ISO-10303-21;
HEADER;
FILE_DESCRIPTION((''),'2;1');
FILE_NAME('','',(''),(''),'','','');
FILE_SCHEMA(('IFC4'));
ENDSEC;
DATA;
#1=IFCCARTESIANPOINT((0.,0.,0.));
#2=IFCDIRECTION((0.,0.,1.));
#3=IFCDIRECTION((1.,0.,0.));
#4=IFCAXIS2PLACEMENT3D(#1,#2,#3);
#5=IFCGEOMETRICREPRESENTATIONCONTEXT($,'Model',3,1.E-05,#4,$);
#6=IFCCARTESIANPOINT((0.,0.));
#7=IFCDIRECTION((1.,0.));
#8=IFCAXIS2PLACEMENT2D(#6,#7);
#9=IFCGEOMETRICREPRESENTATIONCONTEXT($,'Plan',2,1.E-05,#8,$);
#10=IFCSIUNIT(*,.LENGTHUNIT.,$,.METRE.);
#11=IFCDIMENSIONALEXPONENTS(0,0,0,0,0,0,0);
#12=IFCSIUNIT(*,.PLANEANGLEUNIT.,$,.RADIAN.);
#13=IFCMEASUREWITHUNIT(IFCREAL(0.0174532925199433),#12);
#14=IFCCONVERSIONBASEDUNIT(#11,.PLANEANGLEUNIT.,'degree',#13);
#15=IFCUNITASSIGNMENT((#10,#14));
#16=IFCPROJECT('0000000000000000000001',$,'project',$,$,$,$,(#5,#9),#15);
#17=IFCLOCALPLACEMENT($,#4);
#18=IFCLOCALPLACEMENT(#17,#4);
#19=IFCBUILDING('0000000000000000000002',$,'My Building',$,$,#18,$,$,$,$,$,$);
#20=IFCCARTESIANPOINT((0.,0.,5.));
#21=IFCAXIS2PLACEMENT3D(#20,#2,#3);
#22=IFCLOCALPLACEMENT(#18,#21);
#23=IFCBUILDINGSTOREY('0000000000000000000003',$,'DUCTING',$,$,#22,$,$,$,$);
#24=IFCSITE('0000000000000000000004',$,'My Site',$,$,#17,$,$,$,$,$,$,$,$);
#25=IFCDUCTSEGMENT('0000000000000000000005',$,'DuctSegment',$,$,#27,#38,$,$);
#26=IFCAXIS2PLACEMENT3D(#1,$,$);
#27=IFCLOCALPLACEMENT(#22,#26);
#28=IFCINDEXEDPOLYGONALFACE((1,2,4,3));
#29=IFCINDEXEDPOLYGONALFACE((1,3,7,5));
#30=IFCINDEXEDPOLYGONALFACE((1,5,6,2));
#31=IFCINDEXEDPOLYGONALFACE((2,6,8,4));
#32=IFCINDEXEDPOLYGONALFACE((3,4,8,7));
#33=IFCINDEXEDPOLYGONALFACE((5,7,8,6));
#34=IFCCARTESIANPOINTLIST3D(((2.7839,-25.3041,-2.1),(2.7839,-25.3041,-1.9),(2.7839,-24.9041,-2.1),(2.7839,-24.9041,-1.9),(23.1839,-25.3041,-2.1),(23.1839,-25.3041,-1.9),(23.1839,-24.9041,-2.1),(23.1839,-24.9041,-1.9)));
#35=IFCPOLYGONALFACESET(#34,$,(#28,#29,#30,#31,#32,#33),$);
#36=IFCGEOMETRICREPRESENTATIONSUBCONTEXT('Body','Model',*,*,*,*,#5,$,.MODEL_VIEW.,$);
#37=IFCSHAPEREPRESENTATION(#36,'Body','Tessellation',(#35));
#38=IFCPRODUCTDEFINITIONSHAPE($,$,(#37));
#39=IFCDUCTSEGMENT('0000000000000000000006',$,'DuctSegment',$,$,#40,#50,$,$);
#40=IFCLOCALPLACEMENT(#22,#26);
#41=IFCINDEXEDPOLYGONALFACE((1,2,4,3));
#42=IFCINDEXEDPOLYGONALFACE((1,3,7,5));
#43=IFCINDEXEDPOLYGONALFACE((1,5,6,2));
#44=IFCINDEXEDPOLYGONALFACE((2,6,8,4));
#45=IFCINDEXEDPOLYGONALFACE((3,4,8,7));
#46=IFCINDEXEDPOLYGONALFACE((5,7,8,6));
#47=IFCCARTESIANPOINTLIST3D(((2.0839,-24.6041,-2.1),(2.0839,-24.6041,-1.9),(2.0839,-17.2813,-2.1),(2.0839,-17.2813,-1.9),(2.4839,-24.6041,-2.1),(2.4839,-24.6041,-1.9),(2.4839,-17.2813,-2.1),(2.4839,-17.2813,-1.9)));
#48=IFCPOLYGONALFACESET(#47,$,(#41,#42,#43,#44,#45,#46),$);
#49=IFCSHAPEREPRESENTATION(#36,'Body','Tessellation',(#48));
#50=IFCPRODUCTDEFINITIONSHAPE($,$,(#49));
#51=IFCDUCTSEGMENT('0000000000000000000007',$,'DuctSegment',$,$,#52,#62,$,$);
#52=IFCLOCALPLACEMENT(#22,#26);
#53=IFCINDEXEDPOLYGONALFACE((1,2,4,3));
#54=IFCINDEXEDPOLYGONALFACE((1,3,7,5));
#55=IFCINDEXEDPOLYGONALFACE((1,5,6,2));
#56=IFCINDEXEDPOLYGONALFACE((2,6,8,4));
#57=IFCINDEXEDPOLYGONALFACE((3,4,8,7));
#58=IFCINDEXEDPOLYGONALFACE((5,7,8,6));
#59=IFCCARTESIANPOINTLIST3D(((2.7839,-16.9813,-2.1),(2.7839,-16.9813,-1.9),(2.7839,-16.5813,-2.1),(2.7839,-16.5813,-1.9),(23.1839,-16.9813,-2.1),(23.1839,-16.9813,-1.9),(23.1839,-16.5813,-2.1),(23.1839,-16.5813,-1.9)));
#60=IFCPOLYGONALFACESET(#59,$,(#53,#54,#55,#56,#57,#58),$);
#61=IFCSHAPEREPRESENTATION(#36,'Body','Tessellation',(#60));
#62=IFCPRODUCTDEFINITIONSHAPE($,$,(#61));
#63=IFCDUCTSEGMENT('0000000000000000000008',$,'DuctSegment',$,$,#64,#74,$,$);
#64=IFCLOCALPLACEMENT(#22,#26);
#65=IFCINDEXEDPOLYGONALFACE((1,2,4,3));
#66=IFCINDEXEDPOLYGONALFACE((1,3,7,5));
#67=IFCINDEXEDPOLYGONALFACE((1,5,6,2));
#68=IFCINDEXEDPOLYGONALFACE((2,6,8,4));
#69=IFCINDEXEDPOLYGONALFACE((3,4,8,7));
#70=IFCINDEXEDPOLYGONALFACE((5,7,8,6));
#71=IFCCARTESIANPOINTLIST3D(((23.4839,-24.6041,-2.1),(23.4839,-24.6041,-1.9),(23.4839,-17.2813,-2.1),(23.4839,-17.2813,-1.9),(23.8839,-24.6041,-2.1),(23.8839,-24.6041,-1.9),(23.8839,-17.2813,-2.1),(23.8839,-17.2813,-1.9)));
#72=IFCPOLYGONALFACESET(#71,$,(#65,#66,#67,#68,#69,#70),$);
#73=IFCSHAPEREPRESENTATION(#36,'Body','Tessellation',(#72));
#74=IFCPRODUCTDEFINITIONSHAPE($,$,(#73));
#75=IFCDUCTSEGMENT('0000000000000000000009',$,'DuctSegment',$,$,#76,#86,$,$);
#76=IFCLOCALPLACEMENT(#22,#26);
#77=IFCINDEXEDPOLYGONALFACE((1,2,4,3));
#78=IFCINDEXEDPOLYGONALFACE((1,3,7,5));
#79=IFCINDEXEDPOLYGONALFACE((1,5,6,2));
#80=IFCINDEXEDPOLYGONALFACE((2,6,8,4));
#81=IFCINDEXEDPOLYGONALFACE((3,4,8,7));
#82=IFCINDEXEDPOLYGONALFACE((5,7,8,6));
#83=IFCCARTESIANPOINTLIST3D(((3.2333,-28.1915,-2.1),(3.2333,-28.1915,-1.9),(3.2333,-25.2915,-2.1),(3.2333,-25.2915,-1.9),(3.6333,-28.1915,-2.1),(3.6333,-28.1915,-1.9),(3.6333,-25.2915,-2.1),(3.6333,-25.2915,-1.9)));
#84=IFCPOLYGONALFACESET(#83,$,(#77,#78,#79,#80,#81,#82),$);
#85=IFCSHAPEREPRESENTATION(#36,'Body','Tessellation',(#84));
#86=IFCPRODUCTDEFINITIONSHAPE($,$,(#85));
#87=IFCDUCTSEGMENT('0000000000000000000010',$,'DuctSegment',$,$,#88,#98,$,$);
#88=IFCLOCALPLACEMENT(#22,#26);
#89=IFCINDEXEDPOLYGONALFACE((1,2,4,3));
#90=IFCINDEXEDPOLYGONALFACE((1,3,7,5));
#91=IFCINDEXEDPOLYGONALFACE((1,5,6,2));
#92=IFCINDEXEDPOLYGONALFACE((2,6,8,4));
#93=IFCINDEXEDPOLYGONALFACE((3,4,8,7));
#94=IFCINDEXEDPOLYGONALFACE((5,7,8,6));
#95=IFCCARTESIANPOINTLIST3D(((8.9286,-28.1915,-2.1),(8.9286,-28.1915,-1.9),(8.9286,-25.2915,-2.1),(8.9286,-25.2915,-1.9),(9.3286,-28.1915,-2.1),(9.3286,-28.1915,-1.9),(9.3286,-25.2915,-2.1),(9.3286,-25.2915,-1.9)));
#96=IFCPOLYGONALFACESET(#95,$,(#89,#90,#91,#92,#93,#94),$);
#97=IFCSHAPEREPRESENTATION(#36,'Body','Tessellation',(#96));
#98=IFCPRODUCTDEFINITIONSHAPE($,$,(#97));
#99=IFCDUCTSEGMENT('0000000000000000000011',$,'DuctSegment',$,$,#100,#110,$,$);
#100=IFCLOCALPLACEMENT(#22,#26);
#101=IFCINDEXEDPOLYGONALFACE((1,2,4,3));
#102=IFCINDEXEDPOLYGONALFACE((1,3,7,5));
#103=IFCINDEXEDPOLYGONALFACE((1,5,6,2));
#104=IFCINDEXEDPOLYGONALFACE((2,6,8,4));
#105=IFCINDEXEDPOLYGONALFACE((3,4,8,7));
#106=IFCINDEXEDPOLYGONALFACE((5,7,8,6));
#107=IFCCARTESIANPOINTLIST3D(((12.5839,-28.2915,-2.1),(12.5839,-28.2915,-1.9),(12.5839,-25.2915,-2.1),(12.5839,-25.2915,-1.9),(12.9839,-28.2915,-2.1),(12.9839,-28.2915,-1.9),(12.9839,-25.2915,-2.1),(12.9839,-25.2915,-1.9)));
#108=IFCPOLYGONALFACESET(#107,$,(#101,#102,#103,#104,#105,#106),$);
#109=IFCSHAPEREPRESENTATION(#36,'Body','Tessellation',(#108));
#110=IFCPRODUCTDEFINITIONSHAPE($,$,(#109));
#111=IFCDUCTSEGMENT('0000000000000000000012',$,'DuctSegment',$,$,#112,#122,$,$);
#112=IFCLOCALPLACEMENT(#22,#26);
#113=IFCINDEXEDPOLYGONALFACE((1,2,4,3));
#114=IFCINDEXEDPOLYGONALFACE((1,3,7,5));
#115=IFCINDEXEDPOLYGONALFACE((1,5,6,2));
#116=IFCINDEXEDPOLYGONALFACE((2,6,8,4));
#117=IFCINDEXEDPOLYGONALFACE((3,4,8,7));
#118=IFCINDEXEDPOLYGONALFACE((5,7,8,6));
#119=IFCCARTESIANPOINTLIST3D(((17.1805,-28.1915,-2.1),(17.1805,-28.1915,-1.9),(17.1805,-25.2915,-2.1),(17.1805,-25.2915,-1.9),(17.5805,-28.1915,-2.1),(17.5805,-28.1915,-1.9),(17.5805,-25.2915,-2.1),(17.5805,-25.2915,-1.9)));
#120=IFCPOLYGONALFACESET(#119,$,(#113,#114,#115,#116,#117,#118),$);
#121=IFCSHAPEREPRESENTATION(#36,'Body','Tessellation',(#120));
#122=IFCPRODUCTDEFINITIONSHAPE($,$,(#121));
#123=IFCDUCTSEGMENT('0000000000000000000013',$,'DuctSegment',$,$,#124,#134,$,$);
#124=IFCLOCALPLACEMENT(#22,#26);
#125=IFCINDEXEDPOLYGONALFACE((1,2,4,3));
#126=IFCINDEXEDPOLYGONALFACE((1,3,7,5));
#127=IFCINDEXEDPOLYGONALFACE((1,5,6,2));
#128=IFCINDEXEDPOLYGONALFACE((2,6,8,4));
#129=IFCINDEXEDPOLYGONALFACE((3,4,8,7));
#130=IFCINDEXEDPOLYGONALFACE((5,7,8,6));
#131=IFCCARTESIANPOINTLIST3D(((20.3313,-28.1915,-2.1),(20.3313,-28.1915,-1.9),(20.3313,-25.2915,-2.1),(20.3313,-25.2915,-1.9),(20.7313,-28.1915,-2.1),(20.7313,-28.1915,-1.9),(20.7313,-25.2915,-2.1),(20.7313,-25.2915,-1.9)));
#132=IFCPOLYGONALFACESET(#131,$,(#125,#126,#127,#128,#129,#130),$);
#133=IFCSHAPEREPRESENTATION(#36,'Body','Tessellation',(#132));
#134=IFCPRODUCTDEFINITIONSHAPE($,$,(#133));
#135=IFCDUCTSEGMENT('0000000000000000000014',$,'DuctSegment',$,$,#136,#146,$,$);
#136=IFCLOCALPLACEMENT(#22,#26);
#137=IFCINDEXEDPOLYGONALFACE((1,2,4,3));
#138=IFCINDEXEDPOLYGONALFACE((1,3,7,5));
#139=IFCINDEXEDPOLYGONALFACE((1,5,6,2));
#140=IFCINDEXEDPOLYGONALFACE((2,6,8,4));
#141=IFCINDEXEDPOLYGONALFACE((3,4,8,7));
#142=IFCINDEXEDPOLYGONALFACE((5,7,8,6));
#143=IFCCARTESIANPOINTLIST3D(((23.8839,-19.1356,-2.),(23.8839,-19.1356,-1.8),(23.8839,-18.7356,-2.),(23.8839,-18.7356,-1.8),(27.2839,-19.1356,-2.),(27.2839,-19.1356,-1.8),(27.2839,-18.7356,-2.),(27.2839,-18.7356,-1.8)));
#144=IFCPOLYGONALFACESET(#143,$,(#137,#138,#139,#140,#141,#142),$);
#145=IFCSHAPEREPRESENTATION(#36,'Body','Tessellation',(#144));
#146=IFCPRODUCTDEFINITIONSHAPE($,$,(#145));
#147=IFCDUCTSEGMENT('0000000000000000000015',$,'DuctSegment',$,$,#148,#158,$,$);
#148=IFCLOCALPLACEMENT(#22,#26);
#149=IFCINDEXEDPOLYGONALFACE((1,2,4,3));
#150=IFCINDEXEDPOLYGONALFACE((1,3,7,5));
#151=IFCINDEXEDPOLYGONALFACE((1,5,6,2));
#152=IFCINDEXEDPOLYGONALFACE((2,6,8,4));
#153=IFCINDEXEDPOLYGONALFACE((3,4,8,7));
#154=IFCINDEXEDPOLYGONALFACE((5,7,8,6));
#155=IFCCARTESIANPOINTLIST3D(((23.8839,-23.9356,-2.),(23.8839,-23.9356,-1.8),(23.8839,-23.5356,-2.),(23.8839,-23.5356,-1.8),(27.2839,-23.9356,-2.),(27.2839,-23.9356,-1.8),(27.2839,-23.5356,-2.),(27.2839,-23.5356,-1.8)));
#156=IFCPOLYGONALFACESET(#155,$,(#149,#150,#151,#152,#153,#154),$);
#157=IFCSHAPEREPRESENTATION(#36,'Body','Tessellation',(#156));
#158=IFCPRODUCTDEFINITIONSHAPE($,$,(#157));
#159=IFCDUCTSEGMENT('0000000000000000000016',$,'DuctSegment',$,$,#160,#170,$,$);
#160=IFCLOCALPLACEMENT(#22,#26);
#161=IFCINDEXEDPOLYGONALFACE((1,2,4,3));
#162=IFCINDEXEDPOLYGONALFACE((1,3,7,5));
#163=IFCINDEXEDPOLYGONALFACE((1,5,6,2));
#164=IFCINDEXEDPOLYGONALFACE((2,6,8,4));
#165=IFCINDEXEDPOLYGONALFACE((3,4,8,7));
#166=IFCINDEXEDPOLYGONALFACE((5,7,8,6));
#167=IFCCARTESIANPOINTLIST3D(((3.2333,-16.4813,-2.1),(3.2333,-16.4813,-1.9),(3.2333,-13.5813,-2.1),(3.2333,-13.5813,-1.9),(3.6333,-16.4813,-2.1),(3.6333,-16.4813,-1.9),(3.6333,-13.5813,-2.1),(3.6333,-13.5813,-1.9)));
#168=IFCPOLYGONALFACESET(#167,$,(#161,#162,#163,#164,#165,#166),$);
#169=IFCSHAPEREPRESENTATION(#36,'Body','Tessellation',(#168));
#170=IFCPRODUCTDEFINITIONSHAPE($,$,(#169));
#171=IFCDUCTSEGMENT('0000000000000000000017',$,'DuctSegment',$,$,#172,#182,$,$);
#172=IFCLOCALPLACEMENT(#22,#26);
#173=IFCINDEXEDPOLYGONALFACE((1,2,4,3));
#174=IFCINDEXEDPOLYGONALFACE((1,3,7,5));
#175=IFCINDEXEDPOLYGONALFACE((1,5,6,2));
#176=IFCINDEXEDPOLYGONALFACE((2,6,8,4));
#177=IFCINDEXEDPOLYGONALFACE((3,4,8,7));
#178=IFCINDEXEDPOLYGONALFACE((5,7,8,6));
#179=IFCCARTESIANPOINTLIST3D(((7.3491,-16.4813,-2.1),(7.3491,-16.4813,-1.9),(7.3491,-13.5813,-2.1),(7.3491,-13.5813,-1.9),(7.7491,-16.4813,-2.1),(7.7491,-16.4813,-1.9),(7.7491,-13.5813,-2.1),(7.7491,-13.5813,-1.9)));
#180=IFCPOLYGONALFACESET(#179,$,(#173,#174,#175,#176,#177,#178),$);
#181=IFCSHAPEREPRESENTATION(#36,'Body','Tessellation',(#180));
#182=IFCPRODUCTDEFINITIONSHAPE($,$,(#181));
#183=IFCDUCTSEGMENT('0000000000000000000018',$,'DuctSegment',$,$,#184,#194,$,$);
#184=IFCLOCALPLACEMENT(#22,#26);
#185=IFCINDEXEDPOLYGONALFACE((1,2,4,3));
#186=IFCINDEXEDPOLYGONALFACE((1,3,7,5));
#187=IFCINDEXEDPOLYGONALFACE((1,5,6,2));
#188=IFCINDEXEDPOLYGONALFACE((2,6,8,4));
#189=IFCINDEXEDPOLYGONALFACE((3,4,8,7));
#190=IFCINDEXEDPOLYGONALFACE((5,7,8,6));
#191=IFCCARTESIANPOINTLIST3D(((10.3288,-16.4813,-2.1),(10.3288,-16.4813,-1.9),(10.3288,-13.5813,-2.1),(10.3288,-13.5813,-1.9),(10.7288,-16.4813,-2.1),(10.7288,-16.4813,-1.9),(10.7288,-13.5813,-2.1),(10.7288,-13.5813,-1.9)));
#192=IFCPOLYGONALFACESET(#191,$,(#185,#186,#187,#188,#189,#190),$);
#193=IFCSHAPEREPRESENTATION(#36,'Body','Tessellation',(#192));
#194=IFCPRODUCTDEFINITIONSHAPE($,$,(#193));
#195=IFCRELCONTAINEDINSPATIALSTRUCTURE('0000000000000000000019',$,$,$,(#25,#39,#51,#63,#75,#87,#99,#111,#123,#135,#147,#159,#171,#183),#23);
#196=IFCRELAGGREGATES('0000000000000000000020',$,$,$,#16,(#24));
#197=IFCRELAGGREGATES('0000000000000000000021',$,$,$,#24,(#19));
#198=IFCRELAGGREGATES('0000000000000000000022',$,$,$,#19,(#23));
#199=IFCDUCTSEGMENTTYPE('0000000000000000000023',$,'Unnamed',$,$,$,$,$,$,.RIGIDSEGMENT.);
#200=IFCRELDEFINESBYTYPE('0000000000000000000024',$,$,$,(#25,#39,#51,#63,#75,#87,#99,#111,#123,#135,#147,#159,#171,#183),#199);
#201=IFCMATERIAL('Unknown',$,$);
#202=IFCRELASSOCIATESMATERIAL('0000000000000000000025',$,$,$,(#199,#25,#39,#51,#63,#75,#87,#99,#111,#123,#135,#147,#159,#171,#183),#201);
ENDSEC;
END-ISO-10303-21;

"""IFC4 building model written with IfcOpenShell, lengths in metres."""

from ifc_helpers import new_model, entity, si_unit, converted_unit, frame, origin_with_axes, origin_2d_with_axis, place, context, subcontext, project, spatial, rectangle, extrude, material, material_profile, profile_set, profile_usage, type_object, element, save


model = new_model("IFC4")

# Units and contexts
model_context = context("Model", 3, precision=1e-05, world=origin_with_axes())
plan_context = context("Plan", 2, precision=1e-05, world=origin_2d_with_axis())
body_context = subcontext(model_context, "Body", "Model", "MODEL_VIEW")
ifc_project = project(units=[si_unit("LENGTHUNIT", "METRE"), converted_unit("PLANEANGLEUNIT", "degree", entity("IfcReal", 0.0174532925199433), si_unit("PLANEANGLEUNIT", "RADIAN"), dimensions=[0, 0, 0, 0, 0, 0, 0])], contexts=[model_context, plan_context])

# Site, building, storey
site_placement = place(None, origin_with_axes())
site = spatial("IfcSite", under=ifc_project, at=site_placement, Name="My Site")
building_placement = place(site_placement, origin_with_axes())
building = spatial("IfcBuilding", under=site, at=building_placement, Name="My Building")
storey_placement = place(building_placement, frame((0.0, 0.0, 5.0), z_axis=(0.0, 0.0, 1.0), x_axis=(1.0, 0.0, 0.0)))
storey = spatial("IfcBuildingStorey", under=building, at=storey_placement, Name="DUCTING")

# Duct segments
ifc_material = material(Name="Unknown")
ifc_material_profile = material_profile(ifc_material, rectangle(XDim=0.4, YDim=0.2))
ifc_profile_set = profile_set([ifc_material_profile])
ifc_profile_usage_1 = profile_usage(ifc_profile_set, cardinal=5)
duct_segment_type = type_object("IfcDuctSegmentType", Name="Unnamed", PredefinedType="RIGIDSEGMENT", material=ifc_profile_set)
duct_segment_1_placement = place(storey_placement, frame((2.7839, -25.1041, -2.0), z_axis=(1.0, 0.0, 0.0), x_axis=(0.0, 1.0, 0.0)))
element("IfcDuctSegment", 1, at=duct_segment_1_placement, inside=storey, type_object=duct_segment_type, material=ifc_profile_usage_1, Name="DuctSegment", context=body_context, shape_type="SweptSolid", body=[
    extrude(rectangle(XDim=0.4, YDim=0.2), origin_with_axes(), (0.0, 0.0, 1.0), 20.4),
])
ifc_profile_usage_2 = profile_usage(ifc_profile_set, cardinal=5)
duct_segment_2_placement = place(storey_placement, frame((2.2839, -17.2813, -2.0), z_axis=(0.0, -1.0, 0.0), x_axis=(1.0, 0.0, 0.0)))
element("IfcDuctSegment", 2, at=duct_segment_2_placement, inside=storey, type_object=duct_segment_type, material=ifc_profile_usage_2, Name="DuctSegment", context=body_context, shape_type="SweptSolid", body=[
    extrude(rectangle(XDim=0.4, YDim=0.2), origin_with_axes(), (0.0, 0.0, 1.0), 7.3228),
])
ifc_profile_usage_3 = profile_usage(ifc_profile_set, cardinal=5)
duct_segment_3_placement = place(storey_placement, frame((2.7839, -16.7813, -2.0), z_axis=(1.0, 0.0, 0.0), x_axis=(0.0, 1.0, 0.0)))
element("IfcDuctSegment", 3, at=duct_segment_3_placement, inside=storey, type_object=duct_segment_type, material=ifc_profile_usage_3, Name="DuctSegment", context=body_context, shape_type="SweptSolid", body=[
    extrude(rectangle(XDim=0.4, YDim=0.2), origin_with_axes(), (0.0, 0.0, 1.0), 20.4),
])
ifc_profile_usage_4 = profile_usage(ifc_profile_set, cardinal=5)
duct_segment_4_placement = place(storey_placement, frame((23.6839, -17.2813, -2.0), z_axis=(-0.000001, -1.0, 0.0), x_axis=(1.0, -0.000001, 0.0)))
element("IfcDuctSegment", 4, at=duct_segment_4_placement, inside=storey, type_object=duct_segment_type, material=ifc_profile_usage_4, Name="DuctSegment", context=body_context, shape_type="SweptSolid", body=[
    extrude(rectangle(XDim=0.4, YDim=0.2), origin_with_axes(), (0.0, 0.0, 1.0), 7.3228),
])
ifc_profile_usage_5 = profile_usage(ifc_profile_set, cardinal=5)
duct_segment_5_placement = place(storey_placement, frame((3.4333, -25.2915, -2.0), z_axis=(0.0, -1.0, 0.0), x_axis=(1.0, 0.0, 0.0)))
element("IfcDuctSegment", 5, at=duct_segment_5_placement, inside=storey, type_object=duct_segment_type, material=ifc_profile_usage_5, Name="DuctSegment", context=body_context, shape_type="SweptSolid", body=[
    extrude(rectangle(XDim=0.4, YDim=0.2), origin_with_axes(), (0.0, 0.0, 1.0), 2.9),
])
ifc_profile_usage_6 = profile_usage(ifc_profile_set, cardinal=5)
duct_segment_6_placement = place(storey_placement, frame((9.1286, -25.2915, -2.0), z_axis=(0.0, -1.0, 0.0), x_axis=(1.0, 0.0, 0.0)))
element("IfcDuctSegment", 6, at=duct_segment_6_placement, inside=storey, type_object=duct_segment_type, material=ifc_profile_usage_6, Name="DuctSegment", context=body_context, shape_type="SweptSolid", body=[
    extrude(rectangle(XDim=0.4, YDim=0.2), origin_with_axes(), (0.0, 0.0, 1.0), 2.9),
])
ifc_profile_usage_7 = profile_usage(ifc_profile_set, cardinal=5)
duct_segment_7_placement = place(storey_placement, frame((12.7839, -25.2915, -2.0), z_axis=(0.0, -1.0, 0.0), x_axis=(1.0, 0.0, 0.0)))
element("IfcDuctSegment", 7, at=duct_segment_7_placement, inside=storey, type_object=duct_segment_type, material=ifc_profile_usage_7, Name="DuctSegment", context=body_context, shape_type="SweptSolid", body=[
    extrude(rectangle(XDim=0.4, YDim=0.2), origin_with_axes(), (0.0, 0.0, 1.0), 3.0),
])
ifc_profile_usage_8 = profile_usage(ifc_profile_set, cardinal=5)
duct_segment_8_placement = place(storey_placement, frame((17.3805, -25.2915, -2.0), z_axis=(0.0, -1.0, 0.0), x_axis=(1.0, 0.0, 0.0)))
element("IfcDuctSegment", 8, at=duct_segment_8_placement, inside=storey, type_object=duct_segment_type, material=ifc_profile_usage_8, Name="DuctSegment", context=body_context, shape_type="SweptSolid", body=[
    extrude(rectangle(XDim=0.4, YDim=0.2), origin_with_axes(), (0.0, 0.0, 1.0), 2.9),
])
ifc_profile_usage_9 = profile_usage(ifc_profile_set, cardinal=5)
duct_segment_9_placement = place(storey_placement, frame((20.5313, -25.2915, -2.0), z_axis=(0.0, -1.0, 0.0), x_axis=(1.0, 0.0, 0.0)))
element("IfcDuctSegment", 9, at=duct_segment_9_placement, inside=storey, type_object=duct_segment_type, material=ifc_profile_usage_9, Name="DuctSegment", context=body_context, shape_type="SweptSolid", body=[
    extrude(rectangle(XDim=0.4, YDim=0.2), origin_with_axes(), (0.0, 0.0, 1.0), 2.9),
])
ifc_profile_usage_10 = profile_usage(ifc_profile_set, cardinal=5)
duct_segment_10_placement = place(storey_placement, frame((23.8839, -18.9356, -1.9), z_axis=(1.0, 0.0, 0.0), x_axis=(0.0, 1.0, 0.0)))
element("IfcDuctSegment", 10, at=duct_segment_10_placement, inside=storey, type_object=duct_segment_type, material=ifc_profile_usage_10, Name="DuctSegment", context=body_context, shape_type="SweptSolid", body=[
    extrude(rectangle(XDim=0.4, YDim=0.2), origin_with_axes(), (0.0, 0.0, 1.0), 3.4),
])
ifc_profile_usage_11 = profile_usage(ifc_profile_set, cardinal=5)
duct_segment_11_placement = place(storey_placement, frame((23.8839, -23.7356, -1.9), z_axis=(1.0, 0.0, 0.0), x_axis=(0.0, 1.0, 0.0)))
element("IfcDuctSegment", 11, at=duct_segment_11_placement, inside=storey, type_object=duct_segment_type, material=ifc_profile_usage_11, Name="DuctSegment", context=body_context, shape_type="SweptSolid", body=[
    extrude(rectangle(XDim=0.4, YDim=0.2), origin_with_axes(), (0.0, 0.0, 1.0), 3.4),
])
ifc_profile_usage_12 = profile_usage(ifc_profile_set, cardinal=5)
duct_segment_12_placement = place(storey_placement, frame((3.4333, -13.5813, -2.0), z_axis=(0.0, -1.0, 0.0), x_axis=(1.0, 0.0, 0.0)))
element("IfcDuctSegment", 12, at=duct_segment_12_placement, inside=storey, type_object=duct_segment_type, material=ifc_profile_usage_12, Name="DuctSegment", context=body_context, shape_type="SweptSolid", body=[
    extrude(rectangle(XDim=0.4, YDim=0.2), origin_with_axes(), (0.0, 0.0, 1.0), 2.9),
])
ifc_profile_usage_13 = profile_usage(ifc_profile_set, cardinal=5)
duct_segment_13_placement = place(storey_placement, frame((7.5491, -13.5813, -2.0), z_axis=(0.0, -1.0, 0.0), x_axis=(1.0, 0.0, 0.0)))
element("IfcDuctSegment", 13, at=duct_segment_13_placement, inside=storey, type_object=duct_segment_type, material=ifc_profile_usage_13, Name="DuctSegment", context=body_context, shape_type="SweptSolid", body=[
    extrude(rectangle(XDim=0.4, YDim=0.2), origin_with_axes(), (0.0, 0.0, 1.0), 2.9),
])
ifc_profile_usage_14 = profile_usage(ifc_profile_set, cardinal=5)
duct_segment_14_placement = place(storey_placement, frame((10.5288, -13.5813, -2.0), z_axis=(0.0, -1.0, 0.0), x_axis=(1.0, 0.0, 0.0)))
element("IfcDuctSegment", 14, at=duct_segment_14_placement, inside=storey, type_object=duct_segment_type, material=ifc_profile_usage_14, Name="DuctSegment", context=body_context, shape_type="SweptSolid", body=[
    extrude(rectangle(XDim=0.4, YDim=0.2), origin_with_axes(), (0.0, 0.0, 1.0), 2.9),
])

save(model, "model.ifc")
